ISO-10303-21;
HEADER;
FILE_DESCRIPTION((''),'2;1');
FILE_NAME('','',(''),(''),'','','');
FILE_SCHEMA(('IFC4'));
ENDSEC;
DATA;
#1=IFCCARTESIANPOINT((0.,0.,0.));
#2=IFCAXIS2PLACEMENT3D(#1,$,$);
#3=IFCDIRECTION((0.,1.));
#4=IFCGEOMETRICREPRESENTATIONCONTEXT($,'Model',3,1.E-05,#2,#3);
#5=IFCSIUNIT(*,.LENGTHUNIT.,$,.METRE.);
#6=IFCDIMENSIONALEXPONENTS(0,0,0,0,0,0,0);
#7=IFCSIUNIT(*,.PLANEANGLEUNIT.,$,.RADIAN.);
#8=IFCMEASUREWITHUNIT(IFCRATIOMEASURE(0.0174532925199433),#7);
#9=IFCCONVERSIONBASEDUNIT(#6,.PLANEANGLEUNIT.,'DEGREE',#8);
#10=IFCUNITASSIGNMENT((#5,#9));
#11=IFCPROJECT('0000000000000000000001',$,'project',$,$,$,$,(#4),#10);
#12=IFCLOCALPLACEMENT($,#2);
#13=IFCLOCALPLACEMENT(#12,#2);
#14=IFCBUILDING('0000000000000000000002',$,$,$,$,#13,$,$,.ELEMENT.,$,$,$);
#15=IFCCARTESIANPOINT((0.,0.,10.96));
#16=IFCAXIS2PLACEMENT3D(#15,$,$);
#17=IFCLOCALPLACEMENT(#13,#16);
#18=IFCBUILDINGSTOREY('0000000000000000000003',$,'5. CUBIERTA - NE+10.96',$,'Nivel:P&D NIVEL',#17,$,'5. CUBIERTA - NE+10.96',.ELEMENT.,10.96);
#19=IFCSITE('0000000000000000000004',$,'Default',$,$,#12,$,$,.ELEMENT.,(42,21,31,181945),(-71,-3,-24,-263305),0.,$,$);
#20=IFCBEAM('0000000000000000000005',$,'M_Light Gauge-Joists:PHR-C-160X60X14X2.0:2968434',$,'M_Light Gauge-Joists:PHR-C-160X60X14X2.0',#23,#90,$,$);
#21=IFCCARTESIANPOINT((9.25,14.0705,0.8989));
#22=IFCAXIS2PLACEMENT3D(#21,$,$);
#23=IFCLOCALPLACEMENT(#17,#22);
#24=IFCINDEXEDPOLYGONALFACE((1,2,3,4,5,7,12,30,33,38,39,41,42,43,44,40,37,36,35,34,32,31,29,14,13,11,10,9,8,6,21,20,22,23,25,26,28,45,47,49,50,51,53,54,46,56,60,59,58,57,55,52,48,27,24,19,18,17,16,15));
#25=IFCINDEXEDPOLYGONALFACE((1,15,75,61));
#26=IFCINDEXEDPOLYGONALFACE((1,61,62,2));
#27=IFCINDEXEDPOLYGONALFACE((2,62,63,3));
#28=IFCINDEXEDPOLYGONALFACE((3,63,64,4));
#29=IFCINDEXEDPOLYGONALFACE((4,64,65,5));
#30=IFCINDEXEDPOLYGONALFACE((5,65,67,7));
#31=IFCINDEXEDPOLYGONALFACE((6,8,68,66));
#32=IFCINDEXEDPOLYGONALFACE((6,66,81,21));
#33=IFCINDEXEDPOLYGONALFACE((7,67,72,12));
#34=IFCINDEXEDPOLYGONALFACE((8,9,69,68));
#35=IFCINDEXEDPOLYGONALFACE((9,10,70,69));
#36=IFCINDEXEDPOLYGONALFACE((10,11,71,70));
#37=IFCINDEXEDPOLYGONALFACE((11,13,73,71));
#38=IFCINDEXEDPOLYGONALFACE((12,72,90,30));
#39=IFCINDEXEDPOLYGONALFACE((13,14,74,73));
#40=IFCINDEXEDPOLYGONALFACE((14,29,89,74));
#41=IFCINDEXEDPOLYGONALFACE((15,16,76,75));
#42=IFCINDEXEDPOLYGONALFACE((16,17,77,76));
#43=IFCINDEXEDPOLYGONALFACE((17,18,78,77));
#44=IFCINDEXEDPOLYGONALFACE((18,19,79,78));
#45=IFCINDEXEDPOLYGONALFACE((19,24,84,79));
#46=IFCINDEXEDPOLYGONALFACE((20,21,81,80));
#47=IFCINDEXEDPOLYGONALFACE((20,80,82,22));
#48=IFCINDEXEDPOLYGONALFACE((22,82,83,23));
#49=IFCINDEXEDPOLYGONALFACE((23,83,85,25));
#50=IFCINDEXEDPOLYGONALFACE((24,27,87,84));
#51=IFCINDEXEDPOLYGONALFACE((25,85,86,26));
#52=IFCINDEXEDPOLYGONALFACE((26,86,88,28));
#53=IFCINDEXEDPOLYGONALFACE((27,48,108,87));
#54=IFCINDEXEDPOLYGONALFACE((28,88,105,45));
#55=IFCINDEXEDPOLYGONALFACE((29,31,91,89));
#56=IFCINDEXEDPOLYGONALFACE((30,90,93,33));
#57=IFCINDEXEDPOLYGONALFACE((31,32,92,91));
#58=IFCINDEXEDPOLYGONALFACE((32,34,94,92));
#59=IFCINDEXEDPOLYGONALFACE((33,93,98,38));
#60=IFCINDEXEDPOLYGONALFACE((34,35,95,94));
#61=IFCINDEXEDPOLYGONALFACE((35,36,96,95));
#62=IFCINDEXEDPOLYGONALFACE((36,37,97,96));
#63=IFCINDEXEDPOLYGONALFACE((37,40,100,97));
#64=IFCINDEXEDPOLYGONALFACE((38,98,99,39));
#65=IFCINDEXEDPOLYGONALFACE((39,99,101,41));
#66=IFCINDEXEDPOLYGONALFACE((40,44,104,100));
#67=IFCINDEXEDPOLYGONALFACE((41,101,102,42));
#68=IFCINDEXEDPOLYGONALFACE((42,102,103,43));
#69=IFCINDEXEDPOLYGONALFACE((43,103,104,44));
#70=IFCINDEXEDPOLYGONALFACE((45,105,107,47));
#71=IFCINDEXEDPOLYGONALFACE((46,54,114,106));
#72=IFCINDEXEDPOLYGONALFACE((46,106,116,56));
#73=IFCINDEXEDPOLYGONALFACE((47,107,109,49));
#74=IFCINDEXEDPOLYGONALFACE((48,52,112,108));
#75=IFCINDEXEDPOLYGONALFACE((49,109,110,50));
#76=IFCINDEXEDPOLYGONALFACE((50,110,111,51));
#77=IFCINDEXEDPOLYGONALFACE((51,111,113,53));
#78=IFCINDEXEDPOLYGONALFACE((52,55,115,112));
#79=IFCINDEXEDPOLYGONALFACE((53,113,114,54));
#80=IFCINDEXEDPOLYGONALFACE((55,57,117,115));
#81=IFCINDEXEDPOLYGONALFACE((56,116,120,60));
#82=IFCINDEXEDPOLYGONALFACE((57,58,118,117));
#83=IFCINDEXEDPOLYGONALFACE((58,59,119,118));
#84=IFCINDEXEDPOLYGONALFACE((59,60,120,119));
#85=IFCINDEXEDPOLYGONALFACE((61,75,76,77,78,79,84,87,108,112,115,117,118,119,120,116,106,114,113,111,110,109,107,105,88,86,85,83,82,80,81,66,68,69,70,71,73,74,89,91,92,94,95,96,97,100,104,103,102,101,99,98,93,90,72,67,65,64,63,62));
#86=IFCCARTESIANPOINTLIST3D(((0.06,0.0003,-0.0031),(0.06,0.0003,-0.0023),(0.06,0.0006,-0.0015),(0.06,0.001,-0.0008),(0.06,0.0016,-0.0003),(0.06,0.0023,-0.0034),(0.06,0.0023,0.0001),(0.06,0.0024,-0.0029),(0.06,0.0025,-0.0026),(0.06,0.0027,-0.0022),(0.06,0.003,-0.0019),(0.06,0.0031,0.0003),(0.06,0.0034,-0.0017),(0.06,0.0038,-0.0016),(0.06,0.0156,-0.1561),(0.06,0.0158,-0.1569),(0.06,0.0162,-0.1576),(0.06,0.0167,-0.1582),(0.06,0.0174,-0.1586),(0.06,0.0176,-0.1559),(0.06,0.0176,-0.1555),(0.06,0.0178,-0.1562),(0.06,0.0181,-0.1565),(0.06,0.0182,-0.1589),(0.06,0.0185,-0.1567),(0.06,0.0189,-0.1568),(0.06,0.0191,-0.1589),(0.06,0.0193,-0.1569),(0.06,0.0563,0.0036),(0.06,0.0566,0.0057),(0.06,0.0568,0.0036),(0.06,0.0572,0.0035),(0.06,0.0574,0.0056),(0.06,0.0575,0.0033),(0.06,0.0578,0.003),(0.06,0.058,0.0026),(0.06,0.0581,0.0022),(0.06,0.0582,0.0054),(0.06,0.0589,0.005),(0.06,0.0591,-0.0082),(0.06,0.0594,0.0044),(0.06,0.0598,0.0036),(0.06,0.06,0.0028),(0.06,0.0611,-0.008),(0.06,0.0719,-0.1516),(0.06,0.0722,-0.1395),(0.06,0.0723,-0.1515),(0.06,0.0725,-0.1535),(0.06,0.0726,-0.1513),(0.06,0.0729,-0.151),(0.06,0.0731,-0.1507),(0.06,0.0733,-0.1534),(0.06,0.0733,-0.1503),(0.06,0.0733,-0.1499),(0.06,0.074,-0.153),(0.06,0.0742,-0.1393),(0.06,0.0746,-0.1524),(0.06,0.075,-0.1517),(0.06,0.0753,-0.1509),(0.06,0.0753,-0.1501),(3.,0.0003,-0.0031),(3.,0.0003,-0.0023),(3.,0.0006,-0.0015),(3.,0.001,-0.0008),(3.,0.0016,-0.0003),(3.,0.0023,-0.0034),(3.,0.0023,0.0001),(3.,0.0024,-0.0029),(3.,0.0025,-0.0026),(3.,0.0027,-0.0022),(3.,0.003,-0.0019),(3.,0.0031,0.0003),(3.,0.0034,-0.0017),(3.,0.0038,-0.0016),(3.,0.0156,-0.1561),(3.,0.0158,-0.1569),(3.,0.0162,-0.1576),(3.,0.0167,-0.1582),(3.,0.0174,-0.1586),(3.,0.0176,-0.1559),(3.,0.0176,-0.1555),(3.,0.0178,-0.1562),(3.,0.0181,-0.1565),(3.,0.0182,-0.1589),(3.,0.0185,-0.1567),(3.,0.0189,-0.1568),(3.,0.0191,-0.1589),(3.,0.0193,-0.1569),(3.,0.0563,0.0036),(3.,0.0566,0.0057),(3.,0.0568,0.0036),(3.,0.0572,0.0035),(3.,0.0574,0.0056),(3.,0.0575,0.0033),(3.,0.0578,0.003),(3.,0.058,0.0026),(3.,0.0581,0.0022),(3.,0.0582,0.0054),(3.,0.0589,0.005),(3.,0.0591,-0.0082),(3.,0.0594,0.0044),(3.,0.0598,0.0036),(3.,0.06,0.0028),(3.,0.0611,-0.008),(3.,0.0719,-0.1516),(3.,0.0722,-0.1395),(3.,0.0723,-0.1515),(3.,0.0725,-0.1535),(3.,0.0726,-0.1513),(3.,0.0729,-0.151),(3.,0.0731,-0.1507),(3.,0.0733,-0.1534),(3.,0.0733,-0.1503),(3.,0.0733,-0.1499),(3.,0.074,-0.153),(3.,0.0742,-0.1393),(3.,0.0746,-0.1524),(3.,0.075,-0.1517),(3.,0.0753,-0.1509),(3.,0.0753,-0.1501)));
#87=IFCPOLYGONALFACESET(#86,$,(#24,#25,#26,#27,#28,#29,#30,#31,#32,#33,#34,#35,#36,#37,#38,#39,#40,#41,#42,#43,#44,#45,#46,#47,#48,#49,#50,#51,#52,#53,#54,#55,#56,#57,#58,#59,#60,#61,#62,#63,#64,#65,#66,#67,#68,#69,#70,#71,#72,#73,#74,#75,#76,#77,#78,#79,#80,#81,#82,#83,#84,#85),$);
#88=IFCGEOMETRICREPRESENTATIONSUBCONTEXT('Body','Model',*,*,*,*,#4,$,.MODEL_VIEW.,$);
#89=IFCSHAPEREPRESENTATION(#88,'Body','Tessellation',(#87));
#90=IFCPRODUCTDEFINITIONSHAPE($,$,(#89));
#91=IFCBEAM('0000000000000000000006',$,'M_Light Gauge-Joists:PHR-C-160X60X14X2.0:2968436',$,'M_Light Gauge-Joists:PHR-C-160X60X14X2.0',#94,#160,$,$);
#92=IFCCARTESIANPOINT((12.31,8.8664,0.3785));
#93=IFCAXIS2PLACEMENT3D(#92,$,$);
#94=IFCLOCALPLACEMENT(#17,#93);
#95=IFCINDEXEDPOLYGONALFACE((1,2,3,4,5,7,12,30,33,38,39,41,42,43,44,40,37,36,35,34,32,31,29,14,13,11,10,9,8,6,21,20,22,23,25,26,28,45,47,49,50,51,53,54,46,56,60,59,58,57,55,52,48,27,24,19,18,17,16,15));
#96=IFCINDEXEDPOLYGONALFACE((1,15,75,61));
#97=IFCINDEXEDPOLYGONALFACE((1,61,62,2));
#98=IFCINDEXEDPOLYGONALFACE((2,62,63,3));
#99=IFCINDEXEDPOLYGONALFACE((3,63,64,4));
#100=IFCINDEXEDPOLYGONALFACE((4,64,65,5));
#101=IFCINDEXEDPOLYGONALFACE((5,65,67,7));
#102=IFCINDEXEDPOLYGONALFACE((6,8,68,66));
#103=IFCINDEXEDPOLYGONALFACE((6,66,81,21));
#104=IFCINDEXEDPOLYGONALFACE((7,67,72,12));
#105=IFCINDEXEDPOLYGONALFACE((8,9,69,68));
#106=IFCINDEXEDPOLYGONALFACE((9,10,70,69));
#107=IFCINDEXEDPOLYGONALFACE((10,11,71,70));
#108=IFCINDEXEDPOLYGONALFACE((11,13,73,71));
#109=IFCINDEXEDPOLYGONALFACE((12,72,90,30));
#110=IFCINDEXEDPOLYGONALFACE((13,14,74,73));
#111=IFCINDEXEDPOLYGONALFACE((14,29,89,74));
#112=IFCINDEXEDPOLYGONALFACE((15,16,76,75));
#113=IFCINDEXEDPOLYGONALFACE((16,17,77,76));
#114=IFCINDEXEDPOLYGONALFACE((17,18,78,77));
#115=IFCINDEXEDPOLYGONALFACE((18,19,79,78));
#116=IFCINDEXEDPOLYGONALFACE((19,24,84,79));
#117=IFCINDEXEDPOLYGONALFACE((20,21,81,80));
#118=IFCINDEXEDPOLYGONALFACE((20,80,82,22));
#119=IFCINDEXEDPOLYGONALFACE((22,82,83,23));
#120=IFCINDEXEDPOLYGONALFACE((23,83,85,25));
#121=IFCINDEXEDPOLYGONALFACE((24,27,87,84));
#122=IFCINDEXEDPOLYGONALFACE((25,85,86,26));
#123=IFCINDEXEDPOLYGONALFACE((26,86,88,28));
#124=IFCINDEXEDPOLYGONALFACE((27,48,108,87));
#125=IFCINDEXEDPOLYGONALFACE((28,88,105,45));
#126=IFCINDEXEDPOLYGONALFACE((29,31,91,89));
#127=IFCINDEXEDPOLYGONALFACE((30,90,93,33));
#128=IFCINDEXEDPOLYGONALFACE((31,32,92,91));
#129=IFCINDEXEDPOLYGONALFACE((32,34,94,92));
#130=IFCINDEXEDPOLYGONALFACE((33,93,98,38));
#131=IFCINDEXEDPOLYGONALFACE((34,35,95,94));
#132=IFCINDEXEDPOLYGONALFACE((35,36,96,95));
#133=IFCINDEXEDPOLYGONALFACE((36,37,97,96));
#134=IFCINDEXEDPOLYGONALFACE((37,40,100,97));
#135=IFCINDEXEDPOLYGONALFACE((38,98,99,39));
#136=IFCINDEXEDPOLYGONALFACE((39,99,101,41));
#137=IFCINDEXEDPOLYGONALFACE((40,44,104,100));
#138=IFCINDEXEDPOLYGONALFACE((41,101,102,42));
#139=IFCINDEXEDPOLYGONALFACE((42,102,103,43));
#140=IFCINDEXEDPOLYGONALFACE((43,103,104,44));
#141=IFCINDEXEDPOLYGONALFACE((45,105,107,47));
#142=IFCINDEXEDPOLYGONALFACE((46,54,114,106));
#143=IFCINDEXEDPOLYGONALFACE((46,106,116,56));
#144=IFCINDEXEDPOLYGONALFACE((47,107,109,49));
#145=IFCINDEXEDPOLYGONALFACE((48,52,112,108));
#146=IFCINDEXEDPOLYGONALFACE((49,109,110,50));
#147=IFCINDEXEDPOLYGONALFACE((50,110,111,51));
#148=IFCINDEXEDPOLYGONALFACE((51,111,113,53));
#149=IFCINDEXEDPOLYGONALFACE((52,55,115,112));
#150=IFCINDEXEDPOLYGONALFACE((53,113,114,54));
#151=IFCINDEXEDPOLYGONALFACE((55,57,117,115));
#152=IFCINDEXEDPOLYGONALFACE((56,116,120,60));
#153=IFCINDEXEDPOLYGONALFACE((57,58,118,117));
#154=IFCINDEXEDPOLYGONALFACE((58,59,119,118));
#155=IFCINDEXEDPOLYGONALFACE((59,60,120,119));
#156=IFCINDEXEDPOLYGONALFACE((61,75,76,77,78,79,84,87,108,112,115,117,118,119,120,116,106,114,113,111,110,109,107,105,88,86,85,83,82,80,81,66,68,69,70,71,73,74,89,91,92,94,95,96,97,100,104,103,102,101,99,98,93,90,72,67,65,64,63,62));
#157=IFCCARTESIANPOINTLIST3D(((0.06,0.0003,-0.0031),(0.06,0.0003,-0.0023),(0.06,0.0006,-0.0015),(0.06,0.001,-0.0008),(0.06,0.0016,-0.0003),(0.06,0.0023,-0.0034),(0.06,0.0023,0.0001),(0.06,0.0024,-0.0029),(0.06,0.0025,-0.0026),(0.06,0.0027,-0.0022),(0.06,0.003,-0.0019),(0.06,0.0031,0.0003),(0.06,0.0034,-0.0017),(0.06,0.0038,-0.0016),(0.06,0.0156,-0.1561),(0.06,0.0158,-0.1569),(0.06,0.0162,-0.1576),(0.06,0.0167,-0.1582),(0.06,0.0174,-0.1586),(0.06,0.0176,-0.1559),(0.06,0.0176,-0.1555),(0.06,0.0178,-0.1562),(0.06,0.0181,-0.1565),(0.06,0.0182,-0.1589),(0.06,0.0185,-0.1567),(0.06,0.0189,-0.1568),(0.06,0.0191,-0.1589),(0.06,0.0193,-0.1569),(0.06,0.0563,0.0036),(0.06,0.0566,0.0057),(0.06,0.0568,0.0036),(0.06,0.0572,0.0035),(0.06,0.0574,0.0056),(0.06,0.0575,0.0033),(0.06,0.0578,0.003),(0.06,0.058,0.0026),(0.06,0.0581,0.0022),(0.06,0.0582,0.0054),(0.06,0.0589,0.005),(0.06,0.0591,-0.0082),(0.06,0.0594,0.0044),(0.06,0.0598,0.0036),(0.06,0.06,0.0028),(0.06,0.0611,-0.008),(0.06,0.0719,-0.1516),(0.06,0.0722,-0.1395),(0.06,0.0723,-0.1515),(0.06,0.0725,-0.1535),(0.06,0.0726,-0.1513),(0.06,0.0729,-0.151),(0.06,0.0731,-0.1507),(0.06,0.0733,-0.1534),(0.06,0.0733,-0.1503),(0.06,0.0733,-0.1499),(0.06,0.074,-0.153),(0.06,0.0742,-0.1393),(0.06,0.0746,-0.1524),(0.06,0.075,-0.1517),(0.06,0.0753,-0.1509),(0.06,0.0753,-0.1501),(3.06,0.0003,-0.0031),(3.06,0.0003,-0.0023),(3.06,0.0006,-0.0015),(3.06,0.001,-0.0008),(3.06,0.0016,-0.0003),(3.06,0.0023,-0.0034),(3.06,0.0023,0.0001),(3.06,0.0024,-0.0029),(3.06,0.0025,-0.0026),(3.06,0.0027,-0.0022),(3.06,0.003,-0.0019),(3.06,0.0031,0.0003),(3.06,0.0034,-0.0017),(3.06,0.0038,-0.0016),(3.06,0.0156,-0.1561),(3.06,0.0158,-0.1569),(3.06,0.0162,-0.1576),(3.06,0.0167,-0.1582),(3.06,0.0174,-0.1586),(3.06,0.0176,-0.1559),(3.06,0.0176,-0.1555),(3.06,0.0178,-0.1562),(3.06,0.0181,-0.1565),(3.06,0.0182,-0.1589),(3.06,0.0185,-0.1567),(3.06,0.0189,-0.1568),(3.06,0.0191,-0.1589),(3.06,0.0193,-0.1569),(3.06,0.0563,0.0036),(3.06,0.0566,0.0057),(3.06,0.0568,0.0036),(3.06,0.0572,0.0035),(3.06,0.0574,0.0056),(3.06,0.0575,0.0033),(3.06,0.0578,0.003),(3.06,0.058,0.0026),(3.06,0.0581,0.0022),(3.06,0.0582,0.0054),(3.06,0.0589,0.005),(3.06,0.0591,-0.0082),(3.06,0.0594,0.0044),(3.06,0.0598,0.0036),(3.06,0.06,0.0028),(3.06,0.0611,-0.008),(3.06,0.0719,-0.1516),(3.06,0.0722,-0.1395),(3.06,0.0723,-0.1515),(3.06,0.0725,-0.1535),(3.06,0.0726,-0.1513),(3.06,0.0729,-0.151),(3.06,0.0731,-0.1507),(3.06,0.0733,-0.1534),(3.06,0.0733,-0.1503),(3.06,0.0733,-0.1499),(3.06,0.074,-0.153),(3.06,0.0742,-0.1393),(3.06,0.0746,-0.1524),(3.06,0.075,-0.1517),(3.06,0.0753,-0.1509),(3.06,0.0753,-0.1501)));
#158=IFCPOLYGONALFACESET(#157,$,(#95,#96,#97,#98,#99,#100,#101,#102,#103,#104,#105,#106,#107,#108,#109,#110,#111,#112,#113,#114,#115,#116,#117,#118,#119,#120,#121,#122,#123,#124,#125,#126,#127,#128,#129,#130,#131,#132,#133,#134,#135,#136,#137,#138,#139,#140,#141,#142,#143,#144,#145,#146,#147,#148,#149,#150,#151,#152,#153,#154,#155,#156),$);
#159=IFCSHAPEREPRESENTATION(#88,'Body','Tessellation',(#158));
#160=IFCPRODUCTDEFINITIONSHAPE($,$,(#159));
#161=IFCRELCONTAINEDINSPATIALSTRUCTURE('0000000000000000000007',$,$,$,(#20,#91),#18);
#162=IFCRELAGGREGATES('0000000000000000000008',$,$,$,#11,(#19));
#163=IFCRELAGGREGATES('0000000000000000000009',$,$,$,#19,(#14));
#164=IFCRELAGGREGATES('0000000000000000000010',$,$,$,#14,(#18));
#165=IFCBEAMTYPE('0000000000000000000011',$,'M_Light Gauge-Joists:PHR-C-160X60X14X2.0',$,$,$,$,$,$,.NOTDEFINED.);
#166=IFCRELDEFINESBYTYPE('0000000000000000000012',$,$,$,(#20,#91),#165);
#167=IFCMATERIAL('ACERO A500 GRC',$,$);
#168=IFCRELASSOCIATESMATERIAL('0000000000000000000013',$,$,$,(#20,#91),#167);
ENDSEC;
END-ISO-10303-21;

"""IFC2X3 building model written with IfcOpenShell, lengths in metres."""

from ifc_helpers import new_model, entity, si_unit, converted_unit, direction, frame, frame_2d, origin, place, context, subcontext, project, spatial, polyline, circle_curve, parameter, trimmed, segment, composite_curve, outline, extrude, material, type_object, element, save


model = new_model("IFC2X3")

# Units and contexts
model_context = context("Model", 3, precision=1e-05, world=origin(), true_north=direction((0.0, 1.0)))
body_context = subcontext(model_context, "Body", "Model", "MODEL_VIEW")
ifc_project = project(units=[si_unit("LENGTHUNIT", "METRE"), converted_unit("PLANEANGLEUNIT", "DEGREE", entity("IfcRatioMeasure", 0.0174532925199433), si_unit("PLANEANGLEUNIT", "RADIAN"), dimensions=[0, 0, 0, 0, 0, 0, 0])], contexts=[model_context])

# Site, building, storey
site_placement = place(None, origin())
site = spatial("IfcSite", under=ifc_project, at=site_placement, Name="Default", CompositionType="ELEMENT", RefLatitude=(42, 21, 31, 181945), RefLongitude=(-71, -3, -24, -263305), RefElevation=0.0)
building_placement = place(site_placement, origin())
building = spatial("IfcBuilding", under=site, at=building_placement, CompositionType="ELEMENT")
storey_placement = place(building_placement, frame((0.0, 0.0, 10.96)))
storey = spatial("IfcBuildingStorey", under=building, at=storey_placement, Name="5. CUBIERTA - NE+10.96", ObjectType="Nivel:P&D NIVEL", LongName="5. CUBIERTA - NE+10.96", CompositionType="ELEMENT", Elevation=10.96)

# Beams
ifc_material_1 = material(Name="ACERO A500 GRC")
beam_type_1 = type_object("IfcBeamType", Name="M_Light Gauge-Joists:PHR-C-160X60X14X2.0", PredefinedType="NOTDEFINED")
beam_1_placement = place(storey_placement, frame((9.25, 14.0705, 0.8989)))
element("IfcBeam", 1, at=beam_1_placement, inside=storey, type_object=beam_type_1, material=ifc_material_1, Name="M_Light Gauge-Joists:PHR-C-160X60X14X2.0:2968434", ObjectType="M_Light Gauge-Joists:PHR-C-160X60X14X2.0", context=body_context, shape_type="SweptSolid", body=[
    extrude(outline(composite_curve([segment(trimmed(circle_curve(frame_2d((-0.0764, -0.0322), x_axis=(-1.0, 0.0)), 0.0016), [parameter(0.0)], [parameter(90.0)], True, "PARAMETER"), False, "CONTINUOUS"), segment(polyline([(-0.078, -0.0322), (-0.078, 0.0206)]), True, "CONTINUOUS"), segment(trimmed(circle_curve(frame_2d((-0.0764, 0.0206), x_axis=(0.0, 1.0)), 0.0016), [parameter(0.0)], [parameter(90.0)], True, "PARAMETER"), False, "CONTINUOUS"), segment(polyline([(-0.0764, 0.0222), (-0.066, 0.0222)]), True, "CONTINUOUS"), segment(polyline([(-0.066, 0.0222), (-0.066, 0.0242)]), True, "CONTINUOUS"), segment(polyline([(-0.066, 0.0242), (-0.0768, 0.0242)]), True, "CONTINUOUS"), segment(trimmed(circle_curve(frame_2d((-0.0768, 0.021), x_axis=(-1.0, 0.0)), 0.0032), [parameter(270.0)], [parameter(0.0)], True, "PARAMETER"), True, "CONTINUOUS"), segment(polyline([(-0.08, 0.021), (-0.08, -0.0326)]), True, "CONTINUOUS"), segment(trimmed(circle_curve(frame_2d((-0.0768, -0.0326), x_axis=(0.0, -1.0)), 0.0032), [parameter(270.0)], [parameter(0.0)], True, "PARAMETER"), True, "CONTINUOUS"), segment(polyline([(-0.0768, -0.0358), (0.0768, -0.0358)]), True, "CONTINUOUS"), segment(trimmed(circle_curve(frame_2d((0.0768, -0.0326), x_axis=(1.0, 0.0)), 0.0032), [parameter(270.0)], [parameter(0.0)], True, "PARAMETER"), True, "CONTINUOUS"), segment(polyline([(0.08, -0.0326), (0.08, 0.021)]), True, "CONTINUOUS"), segment(trimmed(circle_curve(frame_2d((0.0768, 0.021), x_axis=(0.0, 1.0)), 0.0032), [parameter(270.0)], [parameter(0.0)], True, "PARAMETER"), True, "CONTINUOUS"), segment(polyline([(0.0768, 0.0242), (0.066, 0.0242)]), True, "CONTINUOUS"), segment(polyline([(0.066, 0.0242), (0.066, 0.0222)]), True, "CONTINUOUS"), segment(polyline([(0.066, 0.0222), (0.0764, 0.0222)]), True, "CONTINUOUS"), segment(trimmed(circle_curve(frame_2d((0.0764, 0.0206), x_axis=(1.0, 0.0)), 0.0016), [parameter(0.0)], [parameter(90.0)], True, "PARAMETER"), False, "CONTINUOUS"), segment(polyline([(0.078, 0.0206), (0.078, -0.0322)]), True, "CONTINUOUS"), segment(trimmed(circle_curve(frame_2d((0.0764, -0.0322), x_axis=(0.0, -1.0)), 0.0016), [parameter(0.0)], [parameter(90.0)], True, "PARAMETER"), False, "CONTINUOUS"), segment(polyline([(0.0764, -0.0338), (-0.0764, -0.0338)]), True, "CONTINUOUS")], self_intersect=False)), frame((0.06, 0.0436, -0.076), z_axis=(-1.0, 0.0, 0.0), x_axis=(0.0, -0.099504, 0.995037)), (0.0, 0.0, -1.0), 2.94),
])
beam_2_placement = place(storey_placement, frame((12.31, 8.8664, 0.3785)))
element("IfcBeam", 2, at=beam_2_placement, inside=storey, type_object=beam_type_1, material=ifc_material_1, Name="M_Light Gauge-Joists:PHR-C-160X60X14X2.0:2968436", ObjectType="M_Light Gauge-Joists:PHR-C-160X60X14X2.0", context=body_context, shape_type="SweptSolid", body=[
    extrude(outline(composite_curve([segment(trimmed(circle_curve(frame_2d((-0.0764, -0.0322), x_axis=(-1.0, 0.0)), 0.0016), [parameter(0.0)], [parameter(90.0)], True, "PARAMETER"), False, "CONTINUOUS"), segment(polyline([(-0.078, -0.0322), (-0.078, 0.0206)]), True, "CONTINUOUS"), segment(trimmed(circle_curve(frame_2d((-0.0764, 0.0206), x_axis=(0.0, 1.0)), 0.0016), [parameter(0.0)], [parameter(90.0)], True, "PARAMETER"), False, "CONTINUOUS"), segment(polyline([(-0.0764, 0.0222), (-0.066, 0.0222)]), True, "CONTINUOUS"), segment(polyline([(-0.066, 0.0222), (-0.066, 0.0242)]), True, "CONTINUOUS"), segment(polyline([(-0.066, 0.0242), (-0.0768, 0.0242)]), True, "CONTINUOUS"), segment(trimmed(circle_curve(frame_2d((-0.0768, 0.021), x_axis=(-1.0, 0.0)), 0.0032), [parameter(270.0)], [parameter(0.0)], True, "PARAMETER"), True, "CONTINUOUS"), segment(polyline([(-0.08, 0.021), (-0.08, -0.0326)]), True, "CONTINUOUS"), segment(trimmed(circle_curve(frame_2d((-0.0768, -0.0326), x_axis=(0.0, -1.0)), 0.0032), [parameter(270.0)], [parameter(0.0)], True, "PARAMETER"), True, "CONTINUOUS"), segment(polyline([(-0.0768, -0.0358), (0.0768, -0.0358)]), True, "CONTINUOUS"), segment(trimmed(circle_curve(frame_2d((0.0768, -0.0326), x_axis=(1.0, 0.0)), 0.0032), [parameter(270.0)], [parameter(0.0)], True, "PARAMETER"), True, "CONTINUOUS"), segment(polyline([(0.08, -0.0326), (0.08, 0.021)]), True, "CONTINUOUS"), segment(trimmed(circle_curve(frame_2d((0.0768, 0.021), x_axis=(0.0, 1.0)), 0.0032), [parameter(270.0)], [parameter(0.0)], True, "PARAMETER"), True, "CONTINUOUS"), segment(polyline([(0.0768, 0.0242), (0.066, 0.0242)]), True, "CONTINUOUS"), segment(polyline([(0.066, 0.0242), (0.066, 0.0222)]), True, "CONTINUOUS"), segment(polyline([(0.066, 0.0222), (0.0764, 0.0222)]), True, "CONTINUOUS"), segment(trimmed(circle_curve(frame_2d((0.0764, 0.0206), x_axis=(1.0, 0.0)), 0.0016), [parameter(0.0)], [parameter(90.0)], True, "PARAMETER"), False, "CONTINUOUS"), segment(polyline([(0.078, 0.0206), (0.078, -0.0322)]), True, "CONTINUOUS"), segment(trimmed(circle_curve(frame_2d((0.0764, -0.0322), x_axis=(0.0, -1.0)), 0.0016), [parameter(0.0)], [parameter(90.0)], True, "PARAMETER"), False, "CONTINUOUS"), segment(polyline([(0.0764, -0.0338), (-0.0764, -0.0338)]), True, "CONTINUOUS")], self_intersect=False)), frame((0.06, 0.0436, -0.076), z_axis=(-1.0, 0.0, 0.0), x_axis=(0.0, -0.099504, 0.995037)), (0.0, 0.0, -1.0), 3.0),
])

save(model, "model.ifc")
